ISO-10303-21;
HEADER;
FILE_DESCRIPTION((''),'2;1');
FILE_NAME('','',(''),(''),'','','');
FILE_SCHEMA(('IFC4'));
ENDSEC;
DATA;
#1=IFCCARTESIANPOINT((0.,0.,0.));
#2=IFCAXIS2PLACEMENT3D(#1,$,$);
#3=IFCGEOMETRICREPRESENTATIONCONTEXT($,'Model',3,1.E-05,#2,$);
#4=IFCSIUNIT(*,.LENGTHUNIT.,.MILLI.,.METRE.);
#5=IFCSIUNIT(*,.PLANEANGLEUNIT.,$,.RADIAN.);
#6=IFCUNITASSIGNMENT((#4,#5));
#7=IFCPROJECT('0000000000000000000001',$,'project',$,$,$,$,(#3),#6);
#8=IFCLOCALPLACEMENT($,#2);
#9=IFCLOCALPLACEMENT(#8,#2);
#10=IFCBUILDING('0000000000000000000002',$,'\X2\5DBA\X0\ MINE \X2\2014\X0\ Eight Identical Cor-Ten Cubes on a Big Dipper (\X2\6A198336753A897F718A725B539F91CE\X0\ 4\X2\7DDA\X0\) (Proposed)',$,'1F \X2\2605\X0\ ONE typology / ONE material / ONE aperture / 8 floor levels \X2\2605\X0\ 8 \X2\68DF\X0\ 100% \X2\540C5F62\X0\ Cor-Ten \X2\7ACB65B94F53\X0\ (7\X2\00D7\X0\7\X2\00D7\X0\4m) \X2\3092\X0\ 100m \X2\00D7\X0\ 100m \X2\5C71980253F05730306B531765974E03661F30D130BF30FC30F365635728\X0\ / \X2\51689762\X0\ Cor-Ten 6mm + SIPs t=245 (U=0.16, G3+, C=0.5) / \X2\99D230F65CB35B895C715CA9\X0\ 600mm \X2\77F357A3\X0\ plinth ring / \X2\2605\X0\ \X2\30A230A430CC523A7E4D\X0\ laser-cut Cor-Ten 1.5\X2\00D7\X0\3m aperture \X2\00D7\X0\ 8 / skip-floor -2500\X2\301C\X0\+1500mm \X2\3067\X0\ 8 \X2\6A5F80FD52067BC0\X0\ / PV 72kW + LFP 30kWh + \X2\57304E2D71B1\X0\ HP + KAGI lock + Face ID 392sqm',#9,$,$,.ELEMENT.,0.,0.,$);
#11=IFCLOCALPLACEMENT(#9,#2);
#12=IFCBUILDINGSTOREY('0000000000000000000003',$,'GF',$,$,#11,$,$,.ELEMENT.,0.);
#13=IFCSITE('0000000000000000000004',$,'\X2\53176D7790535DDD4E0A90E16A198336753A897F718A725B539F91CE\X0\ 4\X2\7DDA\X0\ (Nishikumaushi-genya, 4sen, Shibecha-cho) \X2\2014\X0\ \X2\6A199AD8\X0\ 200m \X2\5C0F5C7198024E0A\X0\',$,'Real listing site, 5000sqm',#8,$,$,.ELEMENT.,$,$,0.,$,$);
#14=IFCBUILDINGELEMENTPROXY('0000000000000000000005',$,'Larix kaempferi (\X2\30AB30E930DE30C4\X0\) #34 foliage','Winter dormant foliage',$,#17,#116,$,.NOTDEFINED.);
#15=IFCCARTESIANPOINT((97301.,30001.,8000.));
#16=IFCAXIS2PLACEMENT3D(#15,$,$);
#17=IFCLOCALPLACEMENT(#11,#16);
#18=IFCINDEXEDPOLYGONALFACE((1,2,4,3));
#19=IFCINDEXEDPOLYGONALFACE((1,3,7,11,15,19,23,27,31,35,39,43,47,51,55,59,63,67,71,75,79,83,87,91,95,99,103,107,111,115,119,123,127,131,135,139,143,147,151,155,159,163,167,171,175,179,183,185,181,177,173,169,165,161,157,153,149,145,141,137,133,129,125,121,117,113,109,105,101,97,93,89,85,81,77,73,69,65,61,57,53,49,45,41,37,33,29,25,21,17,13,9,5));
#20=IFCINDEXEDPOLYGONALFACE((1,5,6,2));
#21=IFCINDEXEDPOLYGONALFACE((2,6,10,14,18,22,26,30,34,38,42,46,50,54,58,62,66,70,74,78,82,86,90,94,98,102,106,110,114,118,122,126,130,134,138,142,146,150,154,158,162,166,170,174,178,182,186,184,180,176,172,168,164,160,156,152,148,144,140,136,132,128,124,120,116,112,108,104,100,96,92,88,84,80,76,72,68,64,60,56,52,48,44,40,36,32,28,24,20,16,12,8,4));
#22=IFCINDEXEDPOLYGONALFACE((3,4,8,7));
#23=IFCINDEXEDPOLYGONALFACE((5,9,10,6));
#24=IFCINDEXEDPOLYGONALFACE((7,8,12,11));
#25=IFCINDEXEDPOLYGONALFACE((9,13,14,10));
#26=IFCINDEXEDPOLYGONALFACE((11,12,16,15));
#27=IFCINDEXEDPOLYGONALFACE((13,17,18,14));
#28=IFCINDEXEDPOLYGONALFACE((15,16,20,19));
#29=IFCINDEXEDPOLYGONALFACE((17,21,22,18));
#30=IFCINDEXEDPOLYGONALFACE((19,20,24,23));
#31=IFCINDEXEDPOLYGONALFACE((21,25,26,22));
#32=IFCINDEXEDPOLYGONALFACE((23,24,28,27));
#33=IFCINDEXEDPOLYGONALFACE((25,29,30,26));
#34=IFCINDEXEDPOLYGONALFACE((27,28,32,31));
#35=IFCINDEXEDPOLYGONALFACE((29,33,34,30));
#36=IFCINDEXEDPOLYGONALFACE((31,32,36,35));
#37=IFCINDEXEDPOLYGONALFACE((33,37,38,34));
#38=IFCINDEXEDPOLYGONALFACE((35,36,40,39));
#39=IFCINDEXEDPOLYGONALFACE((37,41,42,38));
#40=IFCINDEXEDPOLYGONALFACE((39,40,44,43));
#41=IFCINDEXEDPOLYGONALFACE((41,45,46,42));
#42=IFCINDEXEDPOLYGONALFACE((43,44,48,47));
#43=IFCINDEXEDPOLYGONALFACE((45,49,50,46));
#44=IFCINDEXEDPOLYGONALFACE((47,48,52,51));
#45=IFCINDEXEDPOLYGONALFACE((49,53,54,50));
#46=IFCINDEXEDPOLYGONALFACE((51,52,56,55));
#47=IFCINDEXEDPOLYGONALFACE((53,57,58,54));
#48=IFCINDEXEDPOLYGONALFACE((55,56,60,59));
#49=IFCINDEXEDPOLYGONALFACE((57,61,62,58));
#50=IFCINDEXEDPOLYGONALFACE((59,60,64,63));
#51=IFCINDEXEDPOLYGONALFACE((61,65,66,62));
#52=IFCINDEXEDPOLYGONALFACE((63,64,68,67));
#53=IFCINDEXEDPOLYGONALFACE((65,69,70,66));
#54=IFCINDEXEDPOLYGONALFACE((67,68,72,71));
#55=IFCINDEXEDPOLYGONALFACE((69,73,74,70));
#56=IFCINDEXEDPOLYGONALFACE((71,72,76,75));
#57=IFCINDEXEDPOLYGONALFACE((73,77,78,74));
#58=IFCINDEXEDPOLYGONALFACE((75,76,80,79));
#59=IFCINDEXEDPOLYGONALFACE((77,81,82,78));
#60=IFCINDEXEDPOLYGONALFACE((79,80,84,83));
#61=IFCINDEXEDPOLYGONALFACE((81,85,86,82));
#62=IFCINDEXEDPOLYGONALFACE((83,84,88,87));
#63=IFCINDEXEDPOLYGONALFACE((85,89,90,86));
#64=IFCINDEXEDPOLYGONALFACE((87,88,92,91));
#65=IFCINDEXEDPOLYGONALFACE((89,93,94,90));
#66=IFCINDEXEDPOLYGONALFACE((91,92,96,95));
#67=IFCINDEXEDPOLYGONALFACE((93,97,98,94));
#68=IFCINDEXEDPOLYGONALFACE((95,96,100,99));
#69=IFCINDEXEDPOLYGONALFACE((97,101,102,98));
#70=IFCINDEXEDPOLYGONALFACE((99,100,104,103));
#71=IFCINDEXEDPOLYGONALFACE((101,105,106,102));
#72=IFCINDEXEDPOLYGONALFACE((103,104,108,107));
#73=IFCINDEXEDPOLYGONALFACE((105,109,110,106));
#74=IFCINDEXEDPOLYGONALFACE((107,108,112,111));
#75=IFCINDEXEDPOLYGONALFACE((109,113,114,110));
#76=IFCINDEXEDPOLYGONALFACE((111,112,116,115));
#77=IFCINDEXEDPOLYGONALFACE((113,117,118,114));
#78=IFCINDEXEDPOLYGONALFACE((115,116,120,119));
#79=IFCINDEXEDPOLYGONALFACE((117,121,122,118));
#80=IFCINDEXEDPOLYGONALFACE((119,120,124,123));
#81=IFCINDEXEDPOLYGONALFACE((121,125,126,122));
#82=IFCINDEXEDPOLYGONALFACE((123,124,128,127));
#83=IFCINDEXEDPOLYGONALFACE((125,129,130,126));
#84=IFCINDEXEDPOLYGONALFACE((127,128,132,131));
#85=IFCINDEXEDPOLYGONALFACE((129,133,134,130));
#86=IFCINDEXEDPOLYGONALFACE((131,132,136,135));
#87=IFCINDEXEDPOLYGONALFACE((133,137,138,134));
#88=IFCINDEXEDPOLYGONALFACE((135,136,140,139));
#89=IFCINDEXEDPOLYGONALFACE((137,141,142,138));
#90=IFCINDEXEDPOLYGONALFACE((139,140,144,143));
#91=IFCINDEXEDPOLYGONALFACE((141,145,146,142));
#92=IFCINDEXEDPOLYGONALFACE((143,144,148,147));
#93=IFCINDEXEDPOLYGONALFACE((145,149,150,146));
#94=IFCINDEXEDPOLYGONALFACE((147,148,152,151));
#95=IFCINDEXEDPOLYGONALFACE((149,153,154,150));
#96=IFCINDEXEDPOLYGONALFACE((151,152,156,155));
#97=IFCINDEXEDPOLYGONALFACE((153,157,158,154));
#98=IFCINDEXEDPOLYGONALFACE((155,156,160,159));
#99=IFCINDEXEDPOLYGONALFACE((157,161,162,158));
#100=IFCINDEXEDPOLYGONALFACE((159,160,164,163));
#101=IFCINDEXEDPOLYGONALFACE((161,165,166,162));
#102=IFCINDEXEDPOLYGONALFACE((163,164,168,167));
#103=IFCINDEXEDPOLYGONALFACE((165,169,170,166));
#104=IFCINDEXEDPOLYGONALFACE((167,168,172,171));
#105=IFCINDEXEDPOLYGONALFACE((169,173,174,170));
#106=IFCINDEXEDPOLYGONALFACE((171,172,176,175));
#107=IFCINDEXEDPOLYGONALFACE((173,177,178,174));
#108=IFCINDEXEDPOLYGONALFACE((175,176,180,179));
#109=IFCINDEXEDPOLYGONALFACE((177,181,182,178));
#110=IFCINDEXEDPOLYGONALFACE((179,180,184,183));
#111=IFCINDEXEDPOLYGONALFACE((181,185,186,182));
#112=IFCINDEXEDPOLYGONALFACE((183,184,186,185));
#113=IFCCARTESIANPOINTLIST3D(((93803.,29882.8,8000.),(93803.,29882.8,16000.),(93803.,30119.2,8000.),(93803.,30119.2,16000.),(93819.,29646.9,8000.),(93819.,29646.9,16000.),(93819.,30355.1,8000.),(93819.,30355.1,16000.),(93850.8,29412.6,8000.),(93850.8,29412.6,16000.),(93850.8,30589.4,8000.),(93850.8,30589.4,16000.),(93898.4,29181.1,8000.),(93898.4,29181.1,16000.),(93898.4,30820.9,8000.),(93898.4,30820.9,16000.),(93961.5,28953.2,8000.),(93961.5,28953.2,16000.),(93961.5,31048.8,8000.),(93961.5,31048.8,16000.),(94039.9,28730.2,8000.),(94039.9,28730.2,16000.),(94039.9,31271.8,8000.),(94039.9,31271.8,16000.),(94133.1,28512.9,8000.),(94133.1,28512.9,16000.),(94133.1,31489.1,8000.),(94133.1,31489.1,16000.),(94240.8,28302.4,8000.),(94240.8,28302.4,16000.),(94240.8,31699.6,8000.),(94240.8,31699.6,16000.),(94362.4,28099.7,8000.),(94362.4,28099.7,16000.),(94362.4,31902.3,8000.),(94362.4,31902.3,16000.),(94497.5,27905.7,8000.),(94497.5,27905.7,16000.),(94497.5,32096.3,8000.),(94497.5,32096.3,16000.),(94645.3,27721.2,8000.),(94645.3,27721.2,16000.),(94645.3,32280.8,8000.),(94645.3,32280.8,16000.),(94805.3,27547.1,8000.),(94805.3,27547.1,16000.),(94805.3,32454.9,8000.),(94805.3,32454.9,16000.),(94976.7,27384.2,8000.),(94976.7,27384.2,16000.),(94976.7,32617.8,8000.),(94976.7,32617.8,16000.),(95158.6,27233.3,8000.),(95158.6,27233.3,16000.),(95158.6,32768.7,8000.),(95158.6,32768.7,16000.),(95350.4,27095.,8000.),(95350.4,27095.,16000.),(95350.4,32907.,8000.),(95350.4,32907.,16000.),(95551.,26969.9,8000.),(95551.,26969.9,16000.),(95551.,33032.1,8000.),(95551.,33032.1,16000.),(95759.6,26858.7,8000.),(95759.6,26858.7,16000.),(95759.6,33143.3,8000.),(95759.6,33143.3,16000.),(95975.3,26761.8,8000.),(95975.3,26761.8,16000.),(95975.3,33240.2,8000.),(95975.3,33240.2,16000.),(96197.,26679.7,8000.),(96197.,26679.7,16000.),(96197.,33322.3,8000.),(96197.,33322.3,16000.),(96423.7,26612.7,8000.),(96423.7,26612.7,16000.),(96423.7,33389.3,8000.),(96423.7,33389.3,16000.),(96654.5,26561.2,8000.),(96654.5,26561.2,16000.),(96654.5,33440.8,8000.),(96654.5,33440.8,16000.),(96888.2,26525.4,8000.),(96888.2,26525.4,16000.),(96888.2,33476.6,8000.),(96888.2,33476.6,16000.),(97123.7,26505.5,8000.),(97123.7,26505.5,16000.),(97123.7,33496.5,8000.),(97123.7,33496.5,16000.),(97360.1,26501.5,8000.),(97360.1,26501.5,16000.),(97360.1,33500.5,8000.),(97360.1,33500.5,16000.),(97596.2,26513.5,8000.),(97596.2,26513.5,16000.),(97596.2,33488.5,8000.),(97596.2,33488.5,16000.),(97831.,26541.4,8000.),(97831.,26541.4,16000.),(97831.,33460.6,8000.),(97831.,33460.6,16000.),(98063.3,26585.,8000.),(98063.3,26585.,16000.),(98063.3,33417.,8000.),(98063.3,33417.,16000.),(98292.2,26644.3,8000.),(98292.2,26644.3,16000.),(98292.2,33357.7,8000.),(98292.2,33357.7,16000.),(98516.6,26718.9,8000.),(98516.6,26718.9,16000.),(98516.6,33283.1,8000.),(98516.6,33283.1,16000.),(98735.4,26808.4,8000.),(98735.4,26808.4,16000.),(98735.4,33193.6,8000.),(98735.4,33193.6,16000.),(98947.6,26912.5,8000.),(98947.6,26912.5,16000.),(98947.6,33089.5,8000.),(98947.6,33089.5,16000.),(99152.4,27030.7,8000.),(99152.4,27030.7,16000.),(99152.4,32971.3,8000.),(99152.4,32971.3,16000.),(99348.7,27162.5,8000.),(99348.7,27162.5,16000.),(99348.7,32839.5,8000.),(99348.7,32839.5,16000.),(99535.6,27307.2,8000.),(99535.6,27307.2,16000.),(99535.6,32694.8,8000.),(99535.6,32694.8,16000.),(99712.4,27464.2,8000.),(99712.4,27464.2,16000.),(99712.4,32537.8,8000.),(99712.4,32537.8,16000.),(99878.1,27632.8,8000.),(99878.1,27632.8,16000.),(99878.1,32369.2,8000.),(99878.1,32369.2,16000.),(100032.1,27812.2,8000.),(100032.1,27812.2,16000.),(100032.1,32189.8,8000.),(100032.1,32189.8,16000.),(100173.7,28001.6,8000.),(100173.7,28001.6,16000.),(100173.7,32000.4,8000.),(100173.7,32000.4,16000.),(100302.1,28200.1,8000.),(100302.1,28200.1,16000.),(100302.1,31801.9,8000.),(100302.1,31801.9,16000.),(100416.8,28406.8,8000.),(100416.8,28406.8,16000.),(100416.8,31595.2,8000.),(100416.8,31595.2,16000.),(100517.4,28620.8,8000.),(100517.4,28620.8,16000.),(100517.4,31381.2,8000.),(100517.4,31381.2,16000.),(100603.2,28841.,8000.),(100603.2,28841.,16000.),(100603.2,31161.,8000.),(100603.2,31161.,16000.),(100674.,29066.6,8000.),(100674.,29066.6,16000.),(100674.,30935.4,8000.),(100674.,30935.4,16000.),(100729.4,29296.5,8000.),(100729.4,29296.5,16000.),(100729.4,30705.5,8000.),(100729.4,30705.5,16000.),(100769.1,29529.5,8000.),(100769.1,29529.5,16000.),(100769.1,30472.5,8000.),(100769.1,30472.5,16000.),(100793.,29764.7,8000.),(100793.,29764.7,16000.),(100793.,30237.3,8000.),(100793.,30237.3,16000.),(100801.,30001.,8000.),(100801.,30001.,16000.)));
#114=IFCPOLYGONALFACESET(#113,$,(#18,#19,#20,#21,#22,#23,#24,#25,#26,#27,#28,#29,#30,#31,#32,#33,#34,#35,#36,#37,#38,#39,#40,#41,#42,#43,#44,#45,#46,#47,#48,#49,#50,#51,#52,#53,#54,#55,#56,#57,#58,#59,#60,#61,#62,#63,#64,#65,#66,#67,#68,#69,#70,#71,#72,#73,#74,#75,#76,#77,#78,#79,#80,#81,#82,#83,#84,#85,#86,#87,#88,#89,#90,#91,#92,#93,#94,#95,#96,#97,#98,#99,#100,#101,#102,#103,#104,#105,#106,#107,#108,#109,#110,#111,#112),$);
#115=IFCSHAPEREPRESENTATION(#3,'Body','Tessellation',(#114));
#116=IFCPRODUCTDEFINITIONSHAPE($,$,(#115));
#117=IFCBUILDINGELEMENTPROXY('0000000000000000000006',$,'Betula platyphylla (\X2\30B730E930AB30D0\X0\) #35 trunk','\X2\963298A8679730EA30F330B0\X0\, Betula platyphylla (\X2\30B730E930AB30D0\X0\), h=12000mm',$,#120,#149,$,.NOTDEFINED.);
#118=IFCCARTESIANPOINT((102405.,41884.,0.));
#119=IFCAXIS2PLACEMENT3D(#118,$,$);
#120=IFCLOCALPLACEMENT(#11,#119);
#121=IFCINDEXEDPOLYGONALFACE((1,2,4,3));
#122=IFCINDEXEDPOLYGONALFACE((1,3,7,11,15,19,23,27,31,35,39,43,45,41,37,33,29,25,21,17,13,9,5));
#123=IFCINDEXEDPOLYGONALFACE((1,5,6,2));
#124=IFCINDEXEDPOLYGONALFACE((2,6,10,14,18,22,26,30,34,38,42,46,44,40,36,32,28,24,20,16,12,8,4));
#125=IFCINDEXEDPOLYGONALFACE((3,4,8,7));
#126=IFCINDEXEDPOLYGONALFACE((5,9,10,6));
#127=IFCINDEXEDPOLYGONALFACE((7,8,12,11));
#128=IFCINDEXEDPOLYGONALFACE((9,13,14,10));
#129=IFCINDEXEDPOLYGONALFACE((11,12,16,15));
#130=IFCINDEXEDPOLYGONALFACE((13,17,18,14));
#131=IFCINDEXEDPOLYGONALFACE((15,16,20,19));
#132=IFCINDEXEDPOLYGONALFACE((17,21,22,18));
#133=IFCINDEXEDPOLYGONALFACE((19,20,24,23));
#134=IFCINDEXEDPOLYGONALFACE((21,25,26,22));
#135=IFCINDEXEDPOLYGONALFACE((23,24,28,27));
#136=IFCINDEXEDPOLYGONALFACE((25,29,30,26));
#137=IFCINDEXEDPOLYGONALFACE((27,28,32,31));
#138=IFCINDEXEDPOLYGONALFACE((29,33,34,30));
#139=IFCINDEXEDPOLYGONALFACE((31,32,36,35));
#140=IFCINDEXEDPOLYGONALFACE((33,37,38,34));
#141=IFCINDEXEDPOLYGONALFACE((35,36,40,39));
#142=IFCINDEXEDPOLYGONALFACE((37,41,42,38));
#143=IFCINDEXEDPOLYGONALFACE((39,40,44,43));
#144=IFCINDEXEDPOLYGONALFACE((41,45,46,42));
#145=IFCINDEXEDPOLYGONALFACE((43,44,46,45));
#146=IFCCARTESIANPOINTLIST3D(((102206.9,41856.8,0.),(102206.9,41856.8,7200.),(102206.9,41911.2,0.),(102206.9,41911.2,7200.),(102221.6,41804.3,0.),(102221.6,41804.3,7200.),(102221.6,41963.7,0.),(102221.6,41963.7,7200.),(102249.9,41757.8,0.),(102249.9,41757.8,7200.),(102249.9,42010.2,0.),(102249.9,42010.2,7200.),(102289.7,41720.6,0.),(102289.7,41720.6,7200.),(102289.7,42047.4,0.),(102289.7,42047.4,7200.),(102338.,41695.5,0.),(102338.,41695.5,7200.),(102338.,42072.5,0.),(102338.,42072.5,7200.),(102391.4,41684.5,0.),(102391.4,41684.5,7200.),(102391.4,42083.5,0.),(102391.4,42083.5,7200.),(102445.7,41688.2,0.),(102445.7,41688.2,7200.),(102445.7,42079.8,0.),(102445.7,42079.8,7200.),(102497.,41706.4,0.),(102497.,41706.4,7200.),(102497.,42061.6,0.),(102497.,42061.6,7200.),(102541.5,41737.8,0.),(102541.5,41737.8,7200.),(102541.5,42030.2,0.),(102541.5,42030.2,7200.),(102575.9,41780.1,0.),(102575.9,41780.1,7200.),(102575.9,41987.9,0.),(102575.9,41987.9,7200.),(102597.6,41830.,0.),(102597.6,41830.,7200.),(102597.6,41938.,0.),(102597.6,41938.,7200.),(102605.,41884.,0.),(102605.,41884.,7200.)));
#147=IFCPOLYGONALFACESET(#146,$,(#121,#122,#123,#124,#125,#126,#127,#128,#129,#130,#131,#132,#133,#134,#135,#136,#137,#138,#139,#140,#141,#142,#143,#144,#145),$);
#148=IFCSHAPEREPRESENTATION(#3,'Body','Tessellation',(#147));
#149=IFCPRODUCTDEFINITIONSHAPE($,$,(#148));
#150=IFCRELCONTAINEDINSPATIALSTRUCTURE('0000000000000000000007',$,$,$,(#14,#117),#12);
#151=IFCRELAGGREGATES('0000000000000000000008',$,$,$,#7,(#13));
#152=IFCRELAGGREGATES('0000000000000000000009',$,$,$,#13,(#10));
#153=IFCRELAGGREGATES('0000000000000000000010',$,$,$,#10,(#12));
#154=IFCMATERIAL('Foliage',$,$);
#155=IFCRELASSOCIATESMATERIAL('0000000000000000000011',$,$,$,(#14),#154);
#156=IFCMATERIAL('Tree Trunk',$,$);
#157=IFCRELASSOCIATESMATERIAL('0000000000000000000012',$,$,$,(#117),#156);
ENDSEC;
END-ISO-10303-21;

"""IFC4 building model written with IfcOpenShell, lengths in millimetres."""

from ifc_helpers import new_model, si_unit, frame, origin, origin_2d, place, context, project, spatial, circle, extrude, material, element, save


model = new_model("IFC4")

# Units and contexts
model_context = context("Model", 3, precision=1e-05, world=origin())
ifc_project = project(units=[si_unit("LENGTHUNIT", "METRE", prefix="MILLI"), si_unit("PLANEANGLEUNIT", "RADIAN")], contexts=[model_context])

# Site, building, storey
site_placement = place(None, origin())
site = spatial("IfcSite", under=ifc_project, at=site_placement, Name="北海道川上郡標茶町西熊牛原野 4線 (Nishikumaushi-genya, 4sen, Shibecha-cho) — 標高 200m 小山頂上", ObjectType="Real listing site, 5000sqm", CompositionType="ELEMENT", RefElevation=0.0)
building_placement = place(site_placement, origin())
building = spatial("IfcBuilding", under=site, at=building_placement, Name="嶺 MINE — Eight Identical Cor-Ten Cubes on a Big Dipper (標茶町西熊牛原野 4線) (Proposed)", ObjectType="1F ★ ONE typology / ONE material / ONE aperture / 8 floor levels ★ 8 棟 100% 同形 Cor-Ten 立方体 (7×7×4m) を 100m × 100m 山頂台地に北斗七星パターン散在 / 全面 Cor-Ten 6mm + SIPs t=245 (U=0.16, G3+, C=0.5) / 駒ヶ岳安山岩 600mm 石垣 plinth ring / ★ アイヌ刺繍 laser-cut Cor-Ten 1.5×3m aperture × 8 / skip-floor -2500〜+1500mm で 8 機能分節 / PV 72kW + LFP 30kWh + 地中熱 HP + KAGI lock + Face ID 392sqm", CompositionType="ELEMENT", ElevationOfRefHeight=0.0, ElevationOfTerrain=0.0)
storey_placement = place(building_placement, origin())
storey = spatial("IfcBuildingStorey", under=building, at=storey_placement, Name="GF", CompositionType="ELEMENT", Elevation=0.0)

# Building element proxies
ifc_material_1 = material(Name="Tree Trunk")
ifc_material_2 = material(Name="Foliage")
proxy_1_placement = place(storey_placement, frame((97301.0, 30001.0, 8000.0)))
element("IfcBuildingElementProxy", 1, at=proxy_1_placement, inside=storey, material=ifc_material_2, Name="Larix kaempferi (カラマツ) #34 foliage", Description="Winter dormant foliage", PredefinedType="NOTDEFINED", context=model_context, shape_type="SweptSolid", body=[
    extrude(circle(Radius=3500.0, at=origin_2d()), frame((97301.0, 30001.0, 8000.0)), (0.0, 0.0, 1.0), 8000.0),
])
proxy_2_placement = place(storey_placement, frame((102405.0, 41884.0, 0.0)))
element("IfcBuildingElementProxy", 2, at=proxy_2_placement, inside=storey, material=ifc_material_1, Name="Betula platyphylla (シラカバ) #35 trunk", Description="防風林リング, Betula platyphylla (シラカバ), h=12000mm", PredefinedType="NOTDEFINED", context=model_context, shape_type="SweptSolid", body=[
    extrude(circle(Radius=200.0, at=origin_2d()), frame((102405.0, 41884.0, 0.0)), (0.0, 0.0, 1.0), 7200.0),
])

save(model, "model.ifc")
